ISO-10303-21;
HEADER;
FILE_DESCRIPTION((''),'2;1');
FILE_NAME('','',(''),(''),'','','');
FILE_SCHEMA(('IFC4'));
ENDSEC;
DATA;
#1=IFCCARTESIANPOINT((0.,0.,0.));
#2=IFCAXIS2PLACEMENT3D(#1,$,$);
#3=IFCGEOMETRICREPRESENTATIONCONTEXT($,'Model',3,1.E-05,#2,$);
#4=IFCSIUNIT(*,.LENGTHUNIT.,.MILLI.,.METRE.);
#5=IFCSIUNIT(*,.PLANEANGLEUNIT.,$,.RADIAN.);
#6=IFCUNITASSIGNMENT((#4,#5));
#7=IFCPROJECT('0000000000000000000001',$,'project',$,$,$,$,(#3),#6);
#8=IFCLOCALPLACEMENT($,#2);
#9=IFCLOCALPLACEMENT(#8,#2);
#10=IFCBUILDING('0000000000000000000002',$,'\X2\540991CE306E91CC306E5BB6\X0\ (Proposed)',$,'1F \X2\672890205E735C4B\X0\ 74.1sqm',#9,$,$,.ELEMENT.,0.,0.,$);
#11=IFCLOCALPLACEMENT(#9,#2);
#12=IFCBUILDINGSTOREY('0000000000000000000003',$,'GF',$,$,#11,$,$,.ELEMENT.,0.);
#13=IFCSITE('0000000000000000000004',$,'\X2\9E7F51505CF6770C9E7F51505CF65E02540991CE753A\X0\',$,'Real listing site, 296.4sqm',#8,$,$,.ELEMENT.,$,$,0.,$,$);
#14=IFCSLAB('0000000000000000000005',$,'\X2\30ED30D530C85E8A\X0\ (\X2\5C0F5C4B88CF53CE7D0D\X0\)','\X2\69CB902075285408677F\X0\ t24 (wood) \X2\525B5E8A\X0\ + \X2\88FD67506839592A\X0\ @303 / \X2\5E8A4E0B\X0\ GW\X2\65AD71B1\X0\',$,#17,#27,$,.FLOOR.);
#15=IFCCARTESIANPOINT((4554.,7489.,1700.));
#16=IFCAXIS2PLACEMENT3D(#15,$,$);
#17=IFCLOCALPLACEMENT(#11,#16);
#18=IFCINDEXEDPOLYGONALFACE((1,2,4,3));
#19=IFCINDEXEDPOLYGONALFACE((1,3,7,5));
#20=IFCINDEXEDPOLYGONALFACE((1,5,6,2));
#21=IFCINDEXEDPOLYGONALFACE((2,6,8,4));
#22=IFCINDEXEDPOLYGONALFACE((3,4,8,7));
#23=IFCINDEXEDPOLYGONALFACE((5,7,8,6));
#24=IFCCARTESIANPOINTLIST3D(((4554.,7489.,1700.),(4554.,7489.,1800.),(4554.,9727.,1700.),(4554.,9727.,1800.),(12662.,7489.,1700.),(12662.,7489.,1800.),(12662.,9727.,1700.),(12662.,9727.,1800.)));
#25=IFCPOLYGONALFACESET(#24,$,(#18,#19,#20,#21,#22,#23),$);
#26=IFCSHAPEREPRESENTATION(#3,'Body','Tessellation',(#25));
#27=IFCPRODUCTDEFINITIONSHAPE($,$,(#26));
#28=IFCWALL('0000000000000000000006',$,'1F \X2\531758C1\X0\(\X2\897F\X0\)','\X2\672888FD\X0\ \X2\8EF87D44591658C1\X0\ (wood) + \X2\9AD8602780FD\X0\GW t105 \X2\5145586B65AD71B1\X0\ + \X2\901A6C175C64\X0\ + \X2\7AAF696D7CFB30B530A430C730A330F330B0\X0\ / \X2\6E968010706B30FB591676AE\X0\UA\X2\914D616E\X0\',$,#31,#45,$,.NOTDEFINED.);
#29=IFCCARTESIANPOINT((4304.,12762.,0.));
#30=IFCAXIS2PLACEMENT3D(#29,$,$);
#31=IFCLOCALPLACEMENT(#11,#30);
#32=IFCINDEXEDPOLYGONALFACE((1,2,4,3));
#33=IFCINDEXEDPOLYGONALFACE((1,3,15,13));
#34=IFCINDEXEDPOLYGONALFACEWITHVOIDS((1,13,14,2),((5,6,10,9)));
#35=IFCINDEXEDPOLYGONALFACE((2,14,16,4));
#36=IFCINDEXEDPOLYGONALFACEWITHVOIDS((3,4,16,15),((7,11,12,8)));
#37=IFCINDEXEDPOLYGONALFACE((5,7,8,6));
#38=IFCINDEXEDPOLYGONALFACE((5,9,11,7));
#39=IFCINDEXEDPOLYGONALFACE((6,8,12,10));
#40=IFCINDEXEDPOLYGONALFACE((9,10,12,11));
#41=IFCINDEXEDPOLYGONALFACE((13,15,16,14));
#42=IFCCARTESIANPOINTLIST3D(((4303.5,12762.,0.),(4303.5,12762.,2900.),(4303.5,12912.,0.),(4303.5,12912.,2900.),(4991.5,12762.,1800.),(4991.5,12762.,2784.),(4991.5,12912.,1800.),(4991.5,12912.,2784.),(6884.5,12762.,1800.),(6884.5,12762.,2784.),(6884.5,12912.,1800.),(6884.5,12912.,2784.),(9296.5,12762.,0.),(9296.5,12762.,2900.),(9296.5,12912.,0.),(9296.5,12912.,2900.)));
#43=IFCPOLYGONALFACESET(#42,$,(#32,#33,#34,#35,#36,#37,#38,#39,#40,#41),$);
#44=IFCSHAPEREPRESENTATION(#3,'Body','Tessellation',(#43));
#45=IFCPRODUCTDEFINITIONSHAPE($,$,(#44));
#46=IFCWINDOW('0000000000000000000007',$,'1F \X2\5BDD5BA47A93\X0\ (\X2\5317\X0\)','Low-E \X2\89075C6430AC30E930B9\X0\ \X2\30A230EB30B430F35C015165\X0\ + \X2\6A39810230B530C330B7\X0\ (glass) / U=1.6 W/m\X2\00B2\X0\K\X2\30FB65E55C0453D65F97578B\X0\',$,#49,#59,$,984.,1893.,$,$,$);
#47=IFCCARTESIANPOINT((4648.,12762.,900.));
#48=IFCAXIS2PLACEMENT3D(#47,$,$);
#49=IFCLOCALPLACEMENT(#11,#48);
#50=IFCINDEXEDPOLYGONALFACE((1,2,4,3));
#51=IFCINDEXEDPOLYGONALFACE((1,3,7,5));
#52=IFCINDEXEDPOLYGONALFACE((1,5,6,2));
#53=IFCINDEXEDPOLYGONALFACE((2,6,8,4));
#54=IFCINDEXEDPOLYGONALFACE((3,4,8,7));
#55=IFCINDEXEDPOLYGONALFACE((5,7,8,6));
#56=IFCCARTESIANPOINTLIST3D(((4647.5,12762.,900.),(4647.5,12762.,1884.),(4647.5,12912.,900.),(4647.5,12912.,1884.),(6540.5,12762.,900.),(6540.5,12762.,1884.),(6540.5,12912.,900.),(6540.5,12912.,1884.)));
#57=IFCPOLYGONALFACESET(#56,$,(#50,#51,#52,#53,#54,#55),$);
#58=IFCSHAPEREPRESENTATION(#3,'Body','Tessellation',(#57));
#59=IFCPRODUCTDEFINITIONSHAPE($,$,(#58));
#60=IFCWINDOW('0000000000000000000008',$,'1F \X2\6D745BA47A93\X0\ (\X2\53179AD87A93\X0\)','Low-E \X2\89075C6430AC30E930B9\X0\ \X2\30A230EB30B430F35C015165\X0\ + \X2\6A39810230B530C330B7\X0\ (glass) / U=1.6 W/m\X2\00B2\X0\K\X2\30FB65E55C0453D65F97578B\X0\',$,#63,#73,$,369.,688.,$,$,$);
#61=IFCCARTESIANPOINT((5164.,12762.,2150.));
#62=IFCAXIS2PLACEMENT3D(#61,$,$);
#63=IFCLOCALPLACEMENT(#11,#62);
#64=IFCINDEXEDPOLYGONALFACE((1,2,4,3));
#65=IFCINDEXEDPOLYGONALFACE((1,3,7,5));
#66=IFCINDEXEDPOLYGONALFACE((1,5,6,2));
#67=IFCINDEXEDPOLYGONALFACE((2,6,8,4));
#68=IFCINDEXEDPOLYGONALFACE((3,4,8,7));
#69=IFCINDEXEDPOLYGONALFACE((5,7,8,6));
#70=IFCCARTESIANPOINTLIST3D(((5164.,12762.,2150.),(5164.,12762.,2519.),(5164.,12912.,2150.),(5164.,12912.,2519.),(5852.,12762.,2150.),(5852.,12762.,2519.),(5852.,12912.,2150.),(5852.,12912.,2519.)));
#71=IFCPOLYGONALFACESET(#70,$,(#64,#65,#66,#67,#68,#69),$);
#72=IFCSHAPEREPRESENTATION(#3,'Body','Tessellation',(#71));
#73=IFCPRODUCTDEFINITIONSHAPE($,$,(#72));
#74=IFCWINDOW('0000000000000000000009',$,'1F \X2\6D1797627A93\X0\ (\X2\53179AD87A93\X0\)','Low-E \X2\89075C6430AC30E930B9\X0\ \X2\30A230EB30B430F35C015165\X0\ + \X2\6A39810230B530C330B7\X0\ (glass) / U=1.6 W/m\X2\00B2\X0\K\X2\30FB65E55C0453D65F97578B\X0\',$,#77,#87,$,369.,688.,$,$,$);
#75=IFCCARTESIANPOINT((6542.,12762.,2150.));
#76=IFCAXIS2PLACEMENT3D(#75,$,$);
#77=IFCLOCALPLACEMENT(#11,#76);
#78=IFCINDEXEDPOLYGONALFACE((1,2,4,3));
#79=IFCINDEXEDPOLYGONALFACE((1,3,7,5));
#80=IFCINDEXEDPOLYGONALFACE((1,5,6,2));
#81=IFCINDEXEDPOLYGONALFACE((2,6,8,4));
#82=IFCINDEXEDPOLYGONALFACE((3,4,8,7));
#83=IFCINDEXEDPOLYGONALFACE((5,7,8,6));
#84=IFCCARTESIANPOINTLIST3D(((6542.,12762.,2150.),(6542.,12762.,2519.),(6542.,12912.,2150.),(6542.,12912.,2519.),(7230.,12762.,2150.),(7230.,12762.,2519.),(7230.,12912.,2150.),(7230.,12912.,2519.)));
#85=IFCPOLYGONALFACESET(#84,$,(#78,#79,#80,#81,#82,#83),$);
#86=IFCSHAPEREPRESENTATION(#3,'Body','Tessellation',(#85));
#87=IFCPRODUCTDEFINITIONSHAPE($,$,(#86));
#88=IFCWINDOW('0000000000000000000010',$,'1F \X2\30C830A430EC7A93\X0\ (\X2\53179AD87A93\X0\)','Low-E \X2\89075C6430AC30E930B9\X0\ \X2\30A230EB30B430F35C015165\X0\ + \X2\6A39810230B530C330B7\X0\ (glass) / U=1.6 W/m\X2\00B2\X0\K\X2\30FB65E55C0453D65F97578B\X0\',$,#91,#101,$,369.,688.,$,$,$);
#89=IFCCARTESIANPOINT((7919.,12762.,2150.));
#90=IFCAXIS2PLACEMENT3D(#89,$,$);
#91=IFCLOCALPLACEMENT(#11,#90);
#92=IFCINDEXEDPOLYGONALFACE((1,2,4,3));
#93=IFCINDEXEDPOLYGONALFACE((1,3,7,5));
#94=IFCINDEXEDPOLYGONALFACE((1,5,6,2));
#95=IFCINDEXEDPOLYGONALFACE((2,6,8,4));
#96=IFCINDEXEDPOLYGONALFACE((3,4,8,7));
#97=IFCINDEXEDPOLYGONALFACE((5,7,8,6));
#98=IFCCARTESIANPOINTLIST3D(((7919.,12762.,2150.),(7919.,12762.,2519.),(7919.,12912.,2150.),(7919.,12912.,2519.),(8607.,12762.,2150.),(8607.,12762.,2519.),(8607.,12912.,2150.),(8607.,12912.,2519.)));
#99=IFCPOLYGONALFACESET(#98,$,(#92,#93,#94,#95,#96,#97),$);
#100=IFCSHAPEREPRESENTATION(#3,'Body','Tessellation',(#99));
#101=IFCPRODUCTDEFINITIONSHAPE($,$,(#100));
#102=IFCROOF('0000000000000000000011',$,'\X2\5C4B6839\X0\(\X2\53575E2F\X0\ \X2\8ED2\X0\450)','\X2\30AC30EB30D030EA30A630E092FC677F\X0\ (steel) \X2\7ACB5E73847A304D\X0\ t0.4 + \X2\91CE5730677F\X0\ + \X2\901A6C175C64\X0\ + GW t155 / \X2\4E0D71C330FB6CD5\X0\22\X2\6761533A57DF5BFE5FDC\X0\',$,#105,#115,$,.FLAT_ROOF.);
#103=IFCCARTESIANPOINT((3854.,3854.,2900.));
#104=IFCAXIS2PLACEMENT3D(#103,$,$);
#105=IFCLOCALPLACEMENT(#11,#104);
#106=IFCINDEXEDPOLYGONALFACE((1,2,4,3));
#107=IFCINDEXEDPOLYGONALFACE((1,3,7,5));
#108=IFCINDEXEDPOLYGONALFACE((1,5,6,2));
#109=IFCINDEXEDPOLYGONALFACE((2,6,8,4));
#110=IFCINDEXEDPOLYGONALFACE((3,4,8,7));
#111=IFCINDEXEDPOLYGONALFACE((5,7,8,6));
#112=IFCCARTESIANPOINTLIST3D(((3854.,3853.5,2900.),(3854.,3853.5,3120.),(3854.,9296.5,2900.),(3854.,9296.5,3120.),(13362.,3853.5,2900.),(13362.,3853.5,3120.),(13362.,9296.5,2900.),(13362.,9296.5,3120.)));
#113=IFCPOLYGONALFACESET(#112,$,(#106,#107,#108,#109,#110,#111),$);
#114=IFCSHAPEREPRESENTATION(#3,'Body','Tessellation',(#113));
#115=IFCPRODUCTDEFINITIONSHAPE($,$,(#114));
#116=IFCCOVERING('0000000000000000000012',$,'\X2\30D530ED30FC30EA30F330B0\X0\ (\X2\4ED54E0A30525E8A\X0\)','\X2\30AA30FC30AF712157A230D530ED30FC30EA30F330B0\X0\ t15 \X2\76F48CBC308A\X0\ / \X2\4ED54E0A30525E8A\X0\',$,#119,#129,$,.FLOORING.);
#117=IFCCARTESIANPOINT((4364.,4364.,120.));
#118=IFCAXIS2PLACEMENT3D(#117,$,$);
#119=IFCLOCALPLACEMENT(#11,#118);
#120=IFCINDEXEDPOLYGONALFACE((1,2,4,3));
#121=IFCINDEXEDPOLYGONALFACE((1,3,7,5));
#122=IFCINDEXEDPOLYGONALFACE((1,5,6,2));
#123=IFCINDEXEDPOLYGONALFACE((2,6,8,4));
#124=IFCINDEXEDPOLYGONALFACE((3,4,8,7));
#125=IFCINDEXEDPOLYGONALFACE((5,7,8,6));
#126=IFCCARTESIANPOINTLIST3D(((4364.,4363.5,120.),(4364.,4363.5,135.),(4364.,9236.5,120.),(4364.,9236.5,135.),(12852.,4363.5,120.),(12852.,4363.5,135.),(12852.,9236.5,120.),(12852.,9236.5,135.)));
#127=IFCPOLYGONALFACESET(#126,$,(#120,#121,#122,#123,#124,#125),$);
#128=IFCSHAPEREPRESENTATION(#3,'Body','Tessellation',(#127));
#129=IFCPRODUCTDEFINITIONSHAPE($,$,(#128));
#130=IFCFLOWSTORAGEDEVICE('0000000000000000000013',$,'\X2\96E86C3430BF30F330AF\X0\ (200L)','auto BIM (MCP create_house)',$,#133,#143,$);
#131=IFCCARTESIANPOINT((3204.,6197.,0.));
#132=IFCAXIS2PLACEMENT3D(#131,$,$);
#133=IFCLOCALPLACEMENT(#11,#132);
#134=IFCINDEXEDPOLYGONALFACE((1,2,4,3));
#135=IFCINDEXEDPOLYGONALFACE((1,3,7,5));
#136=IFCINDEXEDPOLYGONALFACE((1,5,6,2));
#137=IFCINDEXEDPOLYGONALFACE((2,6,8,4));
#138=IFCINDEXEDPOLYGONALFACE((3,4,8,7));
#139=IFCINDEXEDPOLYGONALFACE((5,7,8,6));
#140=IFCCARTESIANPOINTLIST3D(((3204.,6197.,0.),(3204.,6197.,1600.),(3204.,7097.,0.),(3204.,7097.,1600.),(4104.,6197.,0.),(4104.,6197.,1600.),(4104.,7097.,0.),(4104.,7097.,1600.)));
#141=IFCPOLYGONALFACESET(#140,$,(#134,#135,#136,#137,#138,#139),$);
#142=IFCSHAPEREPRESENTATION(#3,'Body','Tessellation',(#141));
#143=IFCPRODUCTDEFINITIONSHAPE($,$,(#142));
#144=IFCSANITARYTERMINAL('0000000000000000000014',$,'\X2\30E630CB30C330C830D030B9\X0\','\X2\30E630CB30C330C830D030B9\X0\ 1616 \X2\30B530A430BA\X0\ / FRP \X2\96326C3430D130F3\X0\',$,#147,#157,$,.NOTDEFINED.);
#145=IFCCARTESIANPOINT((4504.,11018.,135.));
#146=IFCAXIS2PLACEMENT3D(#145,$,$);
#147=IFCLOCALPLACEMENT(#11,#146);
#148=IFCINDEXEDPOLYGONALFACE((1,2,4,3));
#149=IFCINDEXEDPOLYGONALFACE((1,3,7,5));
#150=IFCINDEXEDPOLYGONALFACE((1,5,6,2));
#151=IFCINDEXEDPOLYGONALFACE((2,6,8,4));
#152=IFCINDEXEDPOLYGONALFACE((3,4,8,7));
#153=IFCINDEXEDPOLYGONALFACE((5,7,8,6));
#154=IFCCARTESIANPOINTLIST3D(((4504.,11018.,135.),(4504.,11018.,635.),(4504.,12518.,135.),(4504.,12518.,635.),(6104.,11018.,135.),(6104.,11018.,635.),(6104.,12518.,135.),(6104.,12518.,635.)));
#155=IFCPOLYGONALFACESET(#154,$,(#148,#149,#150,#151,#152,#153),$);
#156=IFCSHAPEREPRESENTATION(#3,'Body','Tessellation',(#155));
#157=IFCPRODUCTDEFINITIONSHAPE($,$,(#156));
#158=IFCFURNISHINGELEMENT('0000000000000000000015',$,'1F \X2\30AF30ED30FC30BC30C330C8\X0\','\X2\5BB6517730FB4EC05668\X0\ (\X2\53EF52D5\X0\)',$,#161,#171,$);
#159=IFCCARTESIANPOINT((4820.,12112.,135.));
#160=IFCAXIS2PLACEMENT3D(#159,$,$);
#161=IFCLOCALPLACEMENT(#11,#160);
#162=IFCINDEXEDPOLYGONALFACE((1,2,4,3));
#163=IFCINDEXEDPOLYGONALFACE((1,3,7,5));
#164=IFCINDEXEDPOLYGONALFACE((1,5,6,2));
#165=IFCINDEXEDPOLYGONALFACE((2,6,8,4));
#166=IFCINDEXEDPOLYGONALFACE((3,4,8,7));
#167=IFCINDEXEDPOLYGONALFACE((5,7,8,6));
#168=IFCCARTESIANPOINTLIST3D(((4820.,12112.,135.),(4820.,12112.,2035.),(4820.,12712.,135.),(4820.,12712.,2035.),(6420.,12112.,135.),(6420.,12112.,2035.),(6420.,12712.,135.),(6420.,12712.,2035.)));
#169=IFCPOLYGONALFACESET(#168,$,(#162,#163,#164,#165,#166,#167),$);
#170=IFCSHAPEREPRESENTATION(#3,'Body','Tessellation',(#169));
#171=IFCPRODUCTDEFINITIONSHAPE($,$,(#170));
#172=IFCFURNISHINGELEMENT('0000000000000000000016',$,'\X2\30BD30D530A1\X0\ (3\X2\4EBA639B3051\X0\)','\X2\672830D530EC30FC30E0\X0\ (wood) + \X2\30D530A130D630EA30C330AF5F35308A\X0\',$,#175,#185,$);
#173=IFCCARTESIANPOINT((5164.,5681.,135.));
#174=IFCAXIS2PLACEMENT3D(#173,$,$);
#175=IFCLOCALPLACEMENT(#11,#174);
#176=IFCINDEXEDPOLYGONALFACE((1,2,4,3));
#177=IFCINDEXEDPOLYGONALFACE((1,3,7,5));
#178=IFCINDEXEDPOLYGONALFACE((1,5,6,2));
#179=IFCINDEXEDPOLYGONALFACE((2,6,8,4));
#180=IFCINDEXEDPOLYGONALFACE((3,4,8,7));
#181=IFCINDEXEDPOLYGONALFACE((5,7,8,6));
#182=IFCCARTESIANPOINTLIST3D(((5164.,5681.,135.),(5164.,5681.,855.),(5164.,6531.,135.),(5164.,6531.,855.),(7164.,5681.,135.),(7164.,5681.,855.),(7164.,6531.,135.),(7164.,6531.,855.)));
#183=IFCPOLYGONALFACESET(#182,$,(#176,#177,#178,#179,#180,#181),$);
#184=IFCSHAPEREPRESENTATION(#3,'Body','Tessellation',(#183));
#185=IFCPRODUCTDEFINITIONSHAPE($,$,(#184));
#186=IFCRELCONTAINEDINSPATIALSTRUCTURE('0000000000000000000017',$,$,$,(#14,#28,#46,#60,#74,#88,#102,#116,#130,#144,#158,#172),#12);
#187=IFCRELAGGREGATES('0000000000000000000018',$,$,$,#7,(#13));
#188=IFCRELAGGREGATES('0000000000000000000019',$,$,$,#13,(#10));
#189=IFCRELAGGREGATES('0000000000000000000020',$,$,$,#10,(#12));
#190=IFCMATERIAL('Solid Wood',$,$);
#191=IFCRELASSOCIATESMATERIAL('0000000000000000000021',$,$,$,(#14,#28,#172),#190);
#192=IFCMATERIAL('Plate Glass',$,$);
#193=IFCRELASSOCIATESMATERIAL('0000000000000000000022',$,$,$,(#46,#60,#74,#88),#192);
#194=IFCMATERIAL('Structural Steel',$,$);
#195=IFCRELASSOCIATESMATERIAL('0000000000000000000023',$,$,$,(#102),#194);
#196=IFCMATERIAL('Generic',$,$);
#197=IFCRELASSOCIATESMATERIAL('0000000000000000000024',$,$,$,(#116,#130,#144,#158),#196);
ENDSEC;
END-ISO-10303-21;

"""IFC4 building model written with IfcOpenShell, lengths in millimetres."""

from ifc_helpers import new_model, si_unit, frame, frame_2d, origin, place, context, project, spatial, rectangle, extrude, material, element, fill, save


model = new_model("IFC4")

# Units and contexts
model_context = context("Model", 3, precision=1e-05, world=origin())
ifc_project = project(units=[si_unit("LENGTHUNIT", "METRE", prefix="MILLI"), si_unit("PLANEANGLEUNIT", "RADIAN")], contexts=[model_context])

# Site, building, storey
site_placement = place(None, origin())
site = spatial("IfcSite", under=ifc_project, at=site_placement, Name="鹿児島県鹿児島市吉野町", ObjectType="Real listing site, 296.4sqm", CompositionType="ELEMENT", RefElevation=0.0)
building_placement = place(site_placement, origin())
building = spatial("IfcBuilding", under=site, at=building_placement, Name="吉野の里の家 (Proposed)", ObjectType="1F 木造平屋 74.1sqm", CompositionType="ELEMENT", ElevationOfRefHeight=0.0, ElevationOfTerrain=0.0)
storey_placement = place(building_placement, origin())
storey = spatial("IfcBuildingStorey", under=building, at=storey_placement, Name="GF", CompositionType="ELEMENT", Elevation=0.0)

# Slab
ifc_material_1 = material(Name="Solid Wood")
slab_1_placement = place(storey_placement, frame((4554.0, 7489.0, 1700.0)))
element("IfcSlab", 1, at=slab_1_placement, inside=storey, material=ifc_material_1, Name="ロフト床 (小屋裏収納)", Description="構造用合板 t24 (wood) 剛床 + 製材根太 @303 / 床下 GW断熱", PredefinedType="FLOOR", context=model_context, shape_type="SweptSolid", body=[
    extrude(rectangle(XDim=8108.0, YDim=2238.0, at=frame_2d((4054.0, 1119.0))), frame((4554.0, 7489.0, 1700.0)), (0.0, 0.0, 1.0), 100.0),
])

# Shared definitions
ifc_material_2 = material(Name="Plate Glass")

# Wall, openings, windows
wall_1_placement = place(storey_placement, frame((4304.0, 12762.0, 0.0)))
wall_1 = element("IfcWall", 2, at=wall_1_placement, inside=storey, material=ifc_material_1, Name="1F 北壁(西)", Description="木製 軸組外壁 (wood) + 高性能GW t105 充填断熱 + 通気層 + 窯業系サイディング / 準耐火・外皮UA配慮", PredefinedType="NOTDEFINED", context=model_context, shape_type="SweptSolid", body=[
    extrude(rectangle(XDim=4993.0, YDim=150.0, at=frame_2d((2496.0, 75.0))), frame((4304.0, 12762.0, 0.0)), (0.0, 0.0, 1.0), 2900.0),
])
opening_1_placement = place(storey_placement, frame((4648.0, 12762.0, 900.0)))
opening_1 = element("IfcOpeningElement", 3, at=opening_1_placement, cuts=wall_1, PredefinedType="NOTDEFINED", context=model_context, shape_type="SweptSolid", body=[
    extrude(rectangle(XDim=1893.0, YDim=150.0, at=frame_2d((946.0, 75.0))), frame((4648.0, 12762.0, 900.0)), (0.0, 0.0, 1.0), 984.0),
])
opening_2_placement = place(storey_placement, frame((5164.0, 12762.0, 2150.0)))
opening_2 = element("IfcOpeningElement", 4, at=opening_2_placement, cuts=wall_1, PredefinedType="NOTDEFINED", context=model_context, shape_type="SweptSolid", body=[
    extrude(rectangle(XDim=688.0, YDim=150.0, at=frame_2d((344.0, 75.0))), frame((5164.0, 12762.0, 2150.0)), (0.0, 0.0, 1.0), 369.0),
])
opening_3_placement = place(storey_placement, frame((6542.0, 12762.0, 2150.0)))
opening_3 = element("IfcOpeningElement", 5, at=opening_3_placement, cuts=wall_1, PredefinedType="NOTDEFINED", context=model_context, shape_type="SweptSolid", body=[
    extrude(rectangle(XDim=688.0, YDim=150.0, at=frame_2d((344.0, 75.0))), frame((6542.0, 12762.0, 2150.0)), (0.0, 0.0, 1.0), 369.0),
])
opening_4_placement = place(storey_placement, frame((7919.0, 12762.0, 2150.0)))
opening_4 = element("IfcOpeningElement", 6, at=opening_4_placement, cuts=wall_1, PredefinedType="NOTDEFINED", context=model_context, shape_type="SweptSolid", body=[
    extrude(rectangle(XDim=688.0, YDim=150.0, at=frame_2d((344.0, 75.0))), frame((7919.0, 12762.0, 2150.0)), (0.0, 0.0, 1.0), 369.0),
])
window_1_placement = place(storey_placement, frame((4648.0, 12762.0, 900.0)))
window_1 = element("IfcWindow", 7, at=window_1_placement, inside=storey, material=ifc_material_2, Name="1F 寝室窓 (北)", Description="Low-E 複層ガラス アルゴン封入 + 樹脂サッシ (glass) / U=1.6 W/m²K・日射取得型", OverallHeight=984.0, OverallWidth=1893.0, context=model_context, shape_type="SweptSolid", body=[
    extrude(rectangle(XDim=1893.0, YDim=150.0, at=frame_2d((946.0, 75.0))), frame((4648.0, 12762.0, 900.0)), (0.0, 0.0, 1.0), 984.0),
])
fill(opening_1, window_1)
window_2_placement = place(storey_placement, frame((5164.0, 12762.0, 2150.0)))
window_2 = element("IfcWindow", 8, at=window_2_placement, inside=storey, material=ifc_material_2, Name="1F 浴室窓 (北高窓)", Description="Low-E 複層ガラス アルゴン封入 + 樹脂サッシ (glass) / U=1.6 W/m²K・日射取得型", OverallHeight=369.0, OverallWidth=688.0, context=model_context, shape_type="SweptSolid", body=[
    extrude(rectangle(XDim=688.0, YDim=150.0, at=frame_2d((344.0, 75.0))), frame((5164.0, 12762.0, 2150.0)), (0.0, 0.0, 1.0), 369.0),
])
fill(opening_2, window_2)
window_3_placement = place(storey_placement, frame((6542.0, 12762.0, 2150.0)))
window_3 = element("IfcWindow", 9, at=window_3_placement, inside=storey, material=ifc_material_2, Name="1F 洗面窓 (北高窓)", Description="Low-E 複層ガラス アルゴン封入 + 樹脂サッシ (glass) / U=1.6 W/m²K・日射取得型", OverallHeight=369.0, OverallWidth=688.0, context=model_context, shape_type="SweptSolid", body=[
    extrude(rectangle(XDim=688.0, YDim=150.0, at=frame_2d((344.0, 75.0))), frame((6542.0, 12762.0, 2150.0)), (0.0, 0.0, 1.0), 369.0),
])
fill(opening_3, window_3)
window_4_placement = place(storey_placement, frame((7919.0, 12762.0, 2150.0)))
window_4 = element("IfcWindow", 10, at=window_4_placement, inside=storey, material=ifc_material_2, Name="1F トイレ窓 (北高窓)", Description="Low-E 複層ガラス アルゴン封入 + 樹脂サッシ (glass) / U=1.6 W/m²K・日射取得型", OverallHeight=369.0, OverallWidth=688.0, context=model_context, shape_type="SweptSolid", body=[
    extrude(rectangle(XDim=688.0, YDim=150.0, at=frame_2d((344.0, 75.0))), frame((7919.0, 12762.0, 2150.0)), (0.0, 0.0, 1.0), 369.0),
])
fill(opening_4, window_4)

# Roof
ifc_material_3 = material(Name="Structural Steel")
roof_1_placement = place(storey_placement, frame((3854.0, 3854.0, 2900.0)))
element("IfcRoof", 11, at=roof_1_placement, inside=storey, material=ifc_material_3, Name="屋根(南帯 軒450)", Description="ガルバリウム鋼板 (steel) 立平葺き t0.4 + 野地板 + 通気層 + GW t155 / 不燃・法22条区域対応", PredefinedType="FLAT_ROOF", context=model_context, shape_type="SweptSolid", body=[
    extrude(rectangle(XDim=9508.0, YDim=5443.0, at=frame_2d((4754.0, 2721.0))), frame((3854.0, 3854.0, 2900.0)), (0.0, 0.0, 1.0), 220.0),
])

# Covering
ifc_material_4 = material(Name="Generic")
covering_1_placement = place(storey_placement, frame((4364.0, 4364.0, 120.0)))
element("IfcCovering", 12, at=covering_1_placement, inside=storey, material=ifc_material_4, Name="フローリング (仕上げ床)", Description="オーク無垢フローリング t15 直貼り / 仕上げ床", PredefinedType="FLOORING", context=model_context, shape_type="SweptSolid", body=[
    extrude(rectangle(XDim=8488.0, YDim=4873.0, at=frame_2d((4244.0, 2436.0))), frame((4364.0, 4364.0, 120.0)), (0.0, 0.0, 1.0), 15.0),
])

# Flow storage device
flow_storage_device_placement = place(storey_placement, frame((3204.0, 6197.0, 0.0)))
element("IfcFlowStorageDevice", 13, at=flow_storage_device_placement, inside=storey, material=ifc_material_4, Name="雨水タンク (200L)", Description="auto BIM (MCP create_house)", context=model_context, shape_type="SweptSolid", body=[
    extrude(rectangle(XDim=900.0, YDim=900.0, at=frame_2d((450.0, 450.0))), frame((3204.0, 6197.0, 0.0)), (0.0, 0.0, 1.0), 1600.0),
])

# Sanitary terminal
sanitary_terminal_placement = place(storey_placement, frame((4504.0, 11018.0, 135.0)))
element("IfcSanitaryTerminal", 14, at=sanitary_terminal_placement, inside=storey, material=ifc_material_4, Name="ユニットバス", Description="ユニットバス 1616 サイズ / FRP 防水パン", PredefinedType="NOTDEFINED", context=model_context, shape_type="SweptSolid", body=[
    extrude(rectangle(XDim=1600.0, YDim=1500.0, at=frame_2d((800.0, 750.0))), frame((4504.0, 11018.0, 135.0)), (0.0, 0.0, 1.0), 500.0),
])

# Furnishing elements
furnishing_1_placement = place(storey_placement, frame((4820.0, 12112.0, 135.0)))
element("IfcFurnishingElement", 15, at=furnishing_1_placement, inside=storey, material=ifc_material_4, Name="1F クローゼット", Description="家具・什器 (可動)", context=model_context, shape_type="SweptSolid", body=[
    extrude(rectangle(XDim=1600.0, YDim=600.0, at=frame_2d((800.0, 300.0))), frame((4820.0, 12112.0, 135.0)), (0.0, 0.0, 1.0), 1900.0),
])
furnishing_2_placement = place(storey_placement, frame((5164.0, 5681.0, 135.0)))
element("IfcFurnishingElement", 16, at=furnishing_2_placement, inside=storey, material=ifc_material_1, Name="ソファ (3人掛け)", Description="木フレーム (wood) + ファブリック張り", context=model_context, shape_type="SweptSolid", body=[
    extrude(rectangle(XDim=2000.0, YDim=850.0, at=frame_2d((1000.0, 425.0))), frame((5164.0, 5681.0, 135.0)), (0.0, 0.0, 1.0), 720.0),
])

save(model, "model.ifc")
